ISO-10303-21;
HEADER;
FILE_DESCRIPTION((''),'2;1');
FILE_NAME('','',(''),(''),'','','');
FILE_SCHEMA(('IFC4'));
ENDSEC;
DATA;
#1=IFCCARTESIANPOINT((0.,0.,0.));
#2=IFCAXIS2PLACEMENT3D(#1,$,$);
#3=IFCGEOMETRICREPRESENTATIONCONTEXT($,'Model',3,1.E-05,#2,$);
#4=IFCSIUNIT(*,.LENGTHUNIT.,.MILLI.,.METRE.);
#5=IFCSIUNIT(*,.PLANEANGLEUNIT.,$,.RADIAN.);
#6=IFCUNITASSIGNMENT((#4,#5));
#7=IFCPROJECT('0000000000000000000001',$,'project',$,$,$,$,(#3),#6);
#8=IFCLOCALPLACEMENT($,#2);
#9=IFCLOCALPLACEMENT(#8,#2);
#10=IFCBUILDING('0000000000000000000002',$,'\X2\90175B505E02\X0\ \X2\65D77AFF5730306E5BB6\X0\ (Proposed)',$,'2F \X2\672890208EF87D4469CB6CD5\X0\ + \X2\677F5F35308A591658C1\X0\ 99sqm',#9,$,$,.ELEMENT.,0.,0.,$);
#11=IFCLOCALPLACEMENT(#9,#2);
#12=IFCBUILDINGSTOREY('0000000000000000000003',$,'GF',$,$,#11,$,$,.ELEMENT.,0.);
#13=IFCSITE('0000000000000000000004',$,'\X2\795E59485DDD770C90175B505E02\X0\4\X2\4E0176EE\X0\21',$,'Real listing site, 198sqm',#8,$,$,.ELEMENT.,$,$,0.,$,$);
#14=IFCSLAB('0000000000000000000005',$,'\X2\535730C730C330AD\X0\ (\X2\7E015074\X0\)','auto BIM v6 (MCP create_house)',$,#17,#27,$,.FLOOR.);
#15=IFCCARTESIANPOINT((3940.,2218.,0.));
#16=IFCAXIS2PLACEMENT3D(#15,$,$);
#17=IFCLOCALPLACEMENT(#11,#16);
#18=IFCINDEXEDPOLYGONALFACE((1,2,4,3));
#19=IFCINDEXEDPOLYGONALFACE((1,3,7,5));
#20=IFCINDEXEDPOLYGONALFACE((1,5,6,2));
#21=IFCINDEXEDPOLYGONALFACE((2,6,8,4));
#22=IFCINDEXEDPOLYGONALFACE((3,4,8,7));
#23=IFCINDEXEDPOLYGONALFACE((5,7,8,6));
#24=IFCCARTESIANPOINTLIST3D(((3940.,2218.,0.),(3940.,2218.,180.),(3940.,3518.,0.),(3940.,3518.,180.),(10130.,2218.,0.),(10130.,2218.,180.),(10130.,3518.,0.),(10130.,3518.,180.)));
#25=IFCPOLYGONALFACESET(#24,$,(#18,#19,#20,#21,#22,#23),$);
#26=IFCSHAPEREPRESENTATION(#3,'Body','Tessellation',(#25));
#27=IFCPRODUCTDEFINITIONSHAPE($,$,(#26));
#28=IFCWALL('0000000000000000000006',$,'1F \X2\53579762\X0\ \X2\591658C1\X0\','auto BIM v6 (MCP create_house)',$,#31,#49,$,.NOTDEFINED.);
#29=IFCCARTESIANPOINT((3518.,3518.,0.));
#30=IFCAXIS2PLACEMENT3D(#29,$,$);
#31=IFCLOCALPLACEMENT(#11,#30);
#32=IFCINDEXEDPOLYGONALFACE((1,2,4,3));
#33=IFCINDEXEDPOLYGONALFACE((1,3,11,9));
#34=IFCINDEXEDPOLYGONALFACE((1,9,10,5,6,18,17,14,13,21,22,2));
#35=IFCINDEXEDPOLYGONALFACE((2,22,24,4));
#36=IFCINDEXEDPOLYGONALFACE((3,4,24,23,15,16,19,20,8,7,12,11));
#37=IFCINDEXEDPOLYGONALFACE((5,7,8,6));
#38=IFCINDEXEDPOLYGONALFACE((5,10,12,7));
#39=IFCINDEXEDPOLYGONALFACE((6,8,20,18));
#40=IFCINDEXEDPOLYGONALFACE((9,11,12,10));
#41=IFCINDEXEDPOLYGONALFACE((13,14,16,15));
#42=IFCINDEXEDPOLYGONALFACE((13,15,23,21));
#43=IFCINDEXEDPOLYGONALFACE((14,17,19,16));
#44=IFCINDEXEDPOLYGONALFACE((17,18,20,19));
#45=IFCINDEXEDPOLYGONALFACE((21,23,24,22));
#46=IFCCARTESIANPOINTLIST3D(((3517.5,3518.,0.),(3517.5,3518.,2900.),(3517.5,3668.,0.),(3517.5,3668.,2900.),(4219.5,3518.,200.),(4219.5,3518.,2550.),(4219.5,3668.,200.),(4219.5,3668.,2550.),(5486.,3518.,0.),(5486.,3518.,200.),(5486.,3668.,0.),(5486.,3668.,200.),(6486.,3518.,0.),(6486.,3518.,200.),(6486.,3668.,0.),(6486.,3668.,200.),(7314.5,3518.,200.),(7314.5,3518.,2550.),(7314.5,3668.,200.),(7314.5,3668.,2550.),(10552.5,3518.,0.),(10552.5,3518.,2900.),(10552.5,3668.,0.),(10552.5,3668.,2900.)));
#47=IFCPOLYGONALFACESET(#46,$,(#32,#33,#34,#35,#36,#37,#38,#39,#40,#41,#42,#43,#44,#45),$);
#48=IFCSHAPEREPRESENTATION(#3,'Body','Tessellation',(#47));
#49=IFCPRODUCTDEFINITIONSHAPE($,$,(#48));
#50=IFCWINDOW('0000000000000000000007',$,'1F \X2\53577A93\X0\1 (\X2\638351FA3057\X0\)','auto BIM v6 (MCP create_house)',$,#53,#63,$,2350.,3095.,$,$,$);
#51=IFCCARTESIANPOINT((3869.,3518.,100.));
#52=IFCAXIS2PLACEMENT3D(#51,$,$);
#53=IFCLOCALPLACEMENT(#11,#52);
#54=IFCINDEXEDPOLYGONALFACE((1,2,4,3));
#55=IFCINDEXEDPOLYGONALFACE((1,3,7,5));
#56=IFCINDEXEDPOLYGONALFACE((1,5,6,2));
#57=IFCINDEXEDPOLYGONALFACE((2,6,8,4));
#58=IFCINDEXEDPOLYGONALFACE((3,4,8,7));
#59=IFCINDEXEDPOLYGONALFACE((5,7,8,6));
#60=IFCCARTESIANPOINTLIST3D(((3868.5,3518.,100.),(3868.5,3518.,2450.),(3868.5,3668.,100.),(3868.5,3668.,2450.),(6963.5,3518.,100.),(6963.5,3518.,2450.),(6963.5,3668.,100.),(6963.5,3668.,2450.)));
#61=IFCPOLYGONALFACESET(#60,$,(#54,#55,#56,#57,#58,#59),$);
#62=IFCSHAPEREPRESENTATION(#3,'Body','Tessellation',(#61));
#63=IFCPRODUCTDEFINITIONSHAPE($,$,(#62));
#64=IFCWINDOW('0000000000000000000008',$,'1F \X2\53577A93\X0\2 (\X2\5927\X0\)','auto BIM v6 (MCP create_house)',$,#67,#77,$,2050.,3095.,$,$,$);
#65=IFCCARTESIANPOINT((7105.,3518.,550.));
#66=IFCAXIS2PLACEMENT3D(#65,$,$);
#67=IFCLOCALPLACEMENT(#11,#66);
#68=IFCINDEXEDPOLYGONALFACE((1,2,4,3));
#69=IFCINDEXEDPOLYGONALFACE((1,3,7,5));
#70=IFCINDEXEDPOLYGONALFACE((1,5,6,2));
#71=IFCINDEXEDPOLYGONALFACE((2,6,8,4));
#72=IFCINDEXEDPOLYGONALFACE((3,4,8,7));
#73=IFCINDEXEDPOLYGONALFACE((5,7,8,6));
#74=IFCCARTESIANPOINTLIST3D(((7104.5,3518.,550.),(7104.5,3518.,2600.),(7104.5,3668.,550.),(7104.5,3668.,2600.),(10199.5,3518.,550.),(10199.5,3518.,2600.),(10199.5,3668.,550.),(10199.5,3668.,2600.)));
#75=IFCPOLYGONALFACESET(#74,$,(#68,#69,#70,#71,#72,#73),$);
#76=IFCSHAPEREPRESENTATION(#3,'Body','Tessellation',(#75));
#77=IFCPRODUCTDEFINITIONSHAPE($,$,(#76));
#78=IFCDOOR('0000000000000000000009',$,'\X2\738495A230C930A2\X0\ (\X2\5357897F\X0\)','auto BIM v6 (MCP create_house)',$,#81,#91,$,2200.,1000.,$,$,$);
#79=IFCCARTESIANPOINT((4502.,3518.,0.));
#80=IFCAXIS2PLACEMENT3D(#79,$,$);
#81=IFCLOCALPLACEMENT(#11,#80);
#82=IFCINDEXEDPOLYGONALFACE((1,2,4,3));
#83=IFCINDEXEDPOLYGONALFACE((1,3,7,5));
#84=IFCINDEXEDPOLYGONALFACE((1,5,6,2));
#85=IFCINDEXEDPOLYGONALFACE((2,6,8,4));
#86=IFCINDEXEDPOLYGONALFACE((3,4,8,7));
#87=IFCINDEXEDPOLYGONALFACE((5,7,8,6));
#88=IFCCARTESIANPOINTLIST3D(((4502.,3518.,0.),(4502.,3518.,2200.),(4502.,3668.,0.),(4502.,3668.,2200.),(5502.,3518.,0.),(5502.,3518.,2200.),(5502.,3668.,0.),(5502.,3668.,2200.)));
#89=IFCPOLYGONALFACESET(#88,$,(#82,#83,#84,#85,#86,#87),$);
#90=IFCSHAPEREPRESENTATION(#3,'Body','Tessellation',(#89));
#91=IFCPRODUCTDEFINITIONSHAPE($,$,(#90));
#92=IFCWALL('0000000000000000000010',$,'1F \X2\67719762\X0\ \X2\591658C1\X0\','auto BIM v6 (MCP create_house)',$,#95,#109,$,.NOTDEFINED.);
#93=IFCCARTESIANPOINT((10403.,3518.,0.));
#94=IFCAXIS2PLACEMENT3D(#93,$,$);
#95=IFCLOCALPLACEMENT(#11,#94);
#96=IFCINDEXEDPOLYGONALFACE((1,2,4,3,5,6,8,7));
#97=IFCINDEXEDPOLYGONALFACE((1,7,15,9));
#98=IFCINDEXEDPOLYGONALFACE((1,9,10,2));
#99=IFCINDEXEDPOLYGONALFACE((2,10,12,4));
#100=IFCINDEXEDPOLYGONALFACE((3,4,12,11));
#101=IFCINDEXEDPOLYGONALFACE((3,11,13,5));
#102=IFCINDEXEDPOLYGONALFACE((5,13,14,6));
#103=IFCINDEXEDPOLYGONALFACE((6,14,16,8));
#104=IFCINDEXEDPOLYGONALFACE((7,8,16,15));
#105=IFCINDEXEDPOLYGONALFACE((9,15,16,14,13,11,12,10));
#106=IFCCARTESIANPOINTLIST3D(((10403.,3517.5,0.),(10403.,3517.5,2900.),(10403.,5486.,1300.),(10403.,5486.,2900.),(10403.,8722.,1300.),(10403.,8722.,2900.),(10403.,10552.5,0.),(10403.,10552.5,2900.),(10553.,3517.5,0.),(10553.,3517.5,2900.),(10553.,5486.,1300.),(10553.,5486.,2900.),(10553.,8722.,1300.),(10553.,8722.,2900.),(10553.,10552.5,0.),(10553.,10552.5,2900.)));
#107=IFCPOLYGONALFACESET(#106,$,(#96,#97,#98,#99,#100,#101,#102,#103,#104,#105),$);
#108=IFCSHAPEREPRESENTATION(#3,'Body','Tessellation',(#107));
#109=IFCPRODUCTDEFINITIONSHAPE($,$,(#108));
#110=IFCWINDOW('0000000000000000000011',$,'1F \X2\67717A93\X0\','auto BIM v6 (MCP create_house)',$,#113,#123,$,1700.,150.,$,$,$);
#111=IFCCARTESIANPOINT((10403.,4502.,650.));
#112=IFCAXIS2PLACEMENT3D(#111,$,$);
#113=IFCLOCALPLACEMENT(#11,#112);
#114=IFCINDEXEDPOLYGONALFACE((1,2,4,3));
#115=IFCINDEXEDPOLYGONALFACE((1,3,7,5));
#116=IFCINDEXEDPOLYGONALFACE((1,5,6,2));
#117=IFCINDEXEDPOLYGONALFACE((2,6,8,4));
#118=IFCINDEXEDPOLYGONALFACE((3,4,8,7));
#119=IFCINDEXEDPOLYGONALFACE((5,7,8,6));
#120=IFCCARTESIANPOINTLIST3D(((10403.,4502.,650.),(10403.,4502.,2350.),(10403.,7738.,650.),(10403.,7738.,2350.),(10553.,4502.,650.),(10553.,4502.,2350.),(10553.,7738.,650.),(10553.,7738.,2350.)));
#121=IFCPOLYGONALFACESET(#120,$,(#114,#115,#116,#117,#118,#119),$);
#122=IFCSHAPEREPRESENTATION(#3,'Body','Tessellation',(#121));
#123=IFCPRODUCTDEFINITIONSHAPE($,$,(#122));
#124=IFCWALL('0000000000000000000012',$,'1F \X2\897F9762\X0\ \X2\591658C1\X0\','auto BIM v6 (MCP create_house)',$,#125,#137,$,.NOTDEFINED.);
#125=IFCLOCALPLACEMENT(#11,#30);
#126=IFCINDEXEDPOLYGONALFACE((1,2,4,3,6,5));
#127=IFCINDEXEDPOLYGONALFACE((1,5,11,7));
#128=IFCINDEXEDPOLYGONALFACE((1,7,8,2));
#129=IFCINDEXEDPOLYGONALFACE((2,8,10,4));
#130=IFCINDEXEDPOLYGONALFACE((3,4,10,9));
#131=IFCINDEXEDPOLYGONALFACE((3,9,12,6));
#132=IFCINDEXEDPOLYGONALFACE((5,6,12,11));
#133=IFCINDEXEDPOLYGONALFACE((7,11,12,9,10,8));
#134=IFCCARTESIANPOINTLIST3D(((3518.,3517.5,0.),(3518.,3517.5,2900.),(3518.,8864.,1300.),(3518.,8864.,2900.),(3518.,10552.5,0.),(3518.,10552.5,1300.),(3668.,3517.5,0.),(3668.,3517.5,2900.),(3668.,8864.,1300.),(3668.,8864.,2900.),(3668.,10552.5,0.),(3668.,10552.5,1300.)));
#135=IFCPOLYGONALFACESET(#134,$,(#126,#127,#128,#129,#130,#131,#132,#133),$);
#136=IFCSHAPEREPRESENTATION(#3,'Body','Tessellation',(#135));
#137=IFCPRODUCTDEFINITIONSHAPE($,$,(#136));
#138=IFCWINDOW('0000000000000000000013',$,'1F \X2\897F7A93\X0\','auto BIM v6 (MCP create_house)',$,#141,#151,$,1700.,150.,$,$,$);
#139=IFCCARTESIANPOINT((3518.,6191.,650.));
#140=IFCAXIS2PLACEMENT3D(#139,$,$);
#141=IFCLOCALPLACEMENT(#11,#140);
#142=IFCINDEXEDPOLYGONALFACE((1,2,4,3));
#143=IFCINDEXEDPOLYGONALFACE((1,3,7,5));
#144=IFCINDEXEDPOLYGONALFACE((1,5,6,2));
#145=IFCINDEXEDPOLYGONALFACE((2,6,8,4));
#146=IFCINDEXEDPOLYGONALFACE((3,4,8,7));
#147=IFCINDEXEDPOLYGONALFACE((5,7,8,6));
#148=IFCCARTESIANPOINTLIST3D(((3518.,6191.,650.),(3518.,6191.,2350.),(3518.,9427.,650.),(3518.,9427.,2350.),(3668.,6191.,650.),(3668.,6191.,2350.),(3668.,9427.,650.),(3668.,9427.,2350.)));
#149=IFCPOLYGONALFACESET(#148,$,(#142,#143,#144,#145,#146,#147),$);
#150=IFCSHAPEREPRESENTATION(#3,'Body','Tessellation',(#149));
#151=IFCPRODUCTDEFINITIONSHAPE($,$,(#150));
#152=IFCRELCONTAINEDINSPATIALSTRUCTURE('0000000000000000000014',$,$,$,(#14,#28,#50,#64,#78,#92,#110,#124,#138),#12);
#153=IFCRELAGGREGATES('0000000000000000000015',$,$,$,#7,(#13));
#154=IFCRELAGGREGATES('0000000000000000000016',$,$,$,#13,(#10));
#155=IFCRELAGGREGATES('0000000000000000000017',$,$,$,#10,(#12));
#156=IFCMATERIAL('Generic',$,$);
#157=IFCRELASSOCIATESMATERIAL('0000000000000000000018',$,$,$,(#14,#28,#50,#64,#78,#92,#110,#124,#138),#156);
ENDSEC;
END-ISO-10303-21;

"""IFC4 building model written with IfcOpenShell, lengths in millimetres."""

from ifc_helpers import new_model, si_unit, frame, frame_2d, origin, place, context, project, spatial, rectangle, extrude, material, element, fill, save


model = new_model("IFC4")

# Units and contexts
model_context = context("Model", 3, precision=1e-05, world=origin())
ifc_project = project(units=[si_unit("LENGTHUNIT", "METRE", prefix="MILLI"), si_unit("PLANEANGLEUNIT", "RADIAN")], contexts=[model_context])

# Site, building, storey
site_placement = place(None, origin())
site = spatial("IfcSite", under=ifc_project, at=site_placement, Name="神奈川県逗子市4丁目21", ObjectType="Real listing site, 198sqm", CompositionType="ELEMENT", RefElevation=0.0)
building_placement = place(site_placement, origin())
building = spatial("IfcBuilding", under=site, at=building_placement, Name="逗子市 旗竿地の家 (Proposed)", ObjectType="2F 木造軸組構法 + 板張り外壁 99sqm", CompositionType="ELEMENT", ElevationOfRefHeight=0.0, ElevationOfTerrain=0.0)
storey_placement = place(building_placement, origin())
storey = spatial("IfcBuildingStorey", under=building, at=storey_placement, Name="GF", CompositionType="ELEMENT", Elevation=0.0)

# Slab
ifc_material = material(Name="Generic")
slab_1_placement = place(storey_placement, frame((3940.0, 2218.0, 0.0)))
element("IfcSlab", 1, at=slab_1_placement, inside=storey, material=ifc_material, Name="南デッキ (縁側)", Description="auto BIM v6 (MCP create_house)", PredefinedType="FLOOR", context=model_context, shape_type="SweptSolid", body=[
    extrude(rectangle(XDim=6190.0, YDim=1300.0, at=frame_2d((3095.0, 650.0))), frame((3940.0, 2218.0, 0.0)), (0.0, 0.0, 1.0), 180.0),
])

# Wall, openings, windows, door
wall_1_placement = place(storey_placement, frame((3518.0, 3518.0, 0.0)))
wall_1 = element("IfcWall", 2, at=wall_1_placement, inside=storey, material=ifc_material, Name="1F 南面 外壁", Description="auto BIM v6 (MCP create_house)", PredefinedType="NOTDEFINED", context=model_context, shape_type="SweptSolid", body=[
    extrude(rectangle(XDim=7035.0, YDim=150.0, at=frame_2d((3517.0, 75.0))), frame((3518.0, 3518.0, 0.0)), (0.0, 0.0, 1.0), 2900.0),
])
opening_1_placement = place(storey_placement, frame((3869.0, 3518.0, 100.0)))
opening_1 = element("IfcOpeningElement", 3, at=opening_1_placement, cuts=wall_1, PredefinedType="NOTDEFINED", context=model_context, shape_type="SweptSolid", body=[
    extrude(rectangle(XDim=3095.0, YDim=150.0, at=frame_2d((1547.0, 75.0))), frame((3869.0, 3518.0, 100.0)), (0.0, 0.0, 1.0), 2350.0),
])
opening_2_placement = place(storey_placement, frame((7105.0, 3518.0, 550.0)))
opening_2 = element("IfcOpeningElement", 4, at=opening_2_placement, cuts=wall_1, PredefinedType="NOTDEFINED", context=model_context, shape_type="SweptSolid", body=[
    extrude(rectangle(XDim=3095.0, YDim=150.0, at=frame_2d((1547.0, 75.0))), frame((7105.0, 3518.0, 550.0)), (0.0, 0.0, 1.0), 2050.0),
])
opening_3_placement = place(storey_placement, frame((4502.0, 3518.0, 0.0)))
opening_3 = element("IfcOpeningElement", 5, at=opening_3_placement, cuts=wall_1, PredefinedType="NOTDEFINED", context=model_context, shape_type="SweptSolid", body=[
    extrude(rectangle(XDim=1000.0, YDim=150.0, at=frame_2d((500.0, 75.0))), frame((4502.0, 3518.0, 0.0)), (0.0, 0.0, 1.0), 2200.0),
])
window_1_placement = place(storey_placement, frame((3869.0, 3518.0, 100.0)))
window_1 = element("IfcWindow", 6, at=window_1_placement, inside=storey, material=ifc_material, Name="1F 南窓1 (掃出し)", Description="auto BIM v6 (MCP create_house)", OverallHeight=2350.0, OverallWidth=3095.0, context=model_context, shape_type="SweptSolid", body=[
    extrude(rectangle(XDim=3095.0, YDim=150.0, at=frame_2d((1547.0, 75.0))), frame((3869.0, 3518.0, 100.0)), (0.0, 0.0, 1.0), 2350.0),
])
fill(opening_1, window_1)
window_2_placement = place(storey_placement, frame((7105.0, 3518.0, 550.0)))
window_2 = element("IfcWindow", 7, at=window_2_placement, inside=storey, material=ifc_material, Name="1F 南窓2 (大)", Description="auto BIM v6 (MCP create_house)", OverallHeight=2050.0, OverallWidth=3095.0, context=model_context, shape_type="SweptSolid", body=[
    extrude(rectangle(XDim=3095.0, YDim=150.0, at=frame_2d((1547.0, 75.0))), frame((7105.0, 3518.0, 550.0)), (0.0, 0.0, 1.0), 2050.0),
])
fill(opening_2, window_2)
door_placement = place(storey_placement, frame((4502.0, 3518.0, 0.0)))
door = element("IfcDoor", 8, at=door_placement, inside=storey, material=ifc_material, Name="玄関ドア (南西)", Description="auto BIM v6 (MCP create_house)", OverallHeight=2200.0, OverallWidth=1000.0, context=model_context, shape_type="SweptSolid", body=[
    extrude(rectangle(XDim=1000.0, YDim=150.0, at=frame_2d((500.0, 75.0))), frame((4502.0, 3518.0, 0.0)), (0.0, 0.0, 1.0), 2200.0),
])
fill(opening_3, door)

# Walls, openings, windows
wall_2_placement = place(storey_placement, frame((10403.0, 3518.0, 0.0)))
wall_2 = element("IfcWall", 9, at=wall_2_placement, inside=storey, material=ifc_material, Name="1F 東面 外壁", Description="auto BIM v6 (MCP create_house)", PredefinedType="NOTDEFINED", context=model_context, shape_type="SweptSolid", body=[
    extrude(rectangle(XDim=150.0, YDim=7035.0, at=frame_2d((75.0, 3517.0))), frame((10403.0, 3518.0, 0.0)), (0.0, 0.0, 1.0), 2900.0),
])
opening_4_placement = place(storey_placement, frame((10403.0, 4502.0, 650.0)))
opening_4 = element("IfcOpeningElement", 10, at=opening_4_placement, cuts=wall_2, PredefinedType="NOTDEFINED", context=model_context, shape_type="SweptSolid", body=[
    extrude(rectangle(XDim=150.0, YDim=3236.0, at=frame_2d((75.0, 1618.0))), frame((10403.0, 4502.0, 650.0)), (0.0, 0.0, 1.0), 1700.0),
])
window_3_placement = place(storey_placement, frame((10403.0, 4502.0, 650.0)))
window_3 = element("IfcWindow", 11, at=window_3_placement, inside=storey, material=ifc_material, Name="1F 東窓", Description="auto BIM v6 (MCP create_house)", OverallHeight=1700.0, OverallWidth=150.0, context=model_context, shape_type="SweptSolid", body=[
    extrude(rectangle(XDim=150.0, YDim=3236.0, at=frame_2d((75.0, 1618.0))), frame((10403.0, 4502.0, 650.0)), (0.0, 0.0, 1.0), 1700.0),
])
fill(opening_4, window_3)
wall_3_placement = place(storey_placement, frame((3518.0, 3518.0, 0.0)))
wall_3 = element("IfcWall", 12, at=wall_3_placement, inside=storey, material=ifc_material, Name="1F 西面 外壁", Description="auto BIM v6 (MCP create_house)", PredefinedType="NOTDEFINED", context=model_context, shape_type="SweptSolid", body=[
    extrude(rectangle(XDim=150.0, YDim=7035.0, at=frame_2d((75.0, 3517.0))), frame((3518.0, 3518.0, 0.0)), (0.0, 0.0, 1.0), 2900.0),
])
opening_5_placement = place(storey_placement, frame((3518.0, 6191.0, 650.0)))
opening_5 = element("IfcOpeningElement", 13, at=opening_5_placement, cuts=wall_3, PredefinedType="NOTDEFINED", context=model_context, shape_type="SweptSolid", body=[
    extrude(rectangle(XDim=150.0, YDim=3236.0, at=frame_2d((75.0, 1618.0))), frame((3518.0, 6191.0, 650.0)), (0.0, 0.0, 1.0), 1700.0),
])
window_4_placement = place(storey_placement, frame((3518.0, 6191.0, 650.0)))
window_4 = element("IfcWindow", 14, at=window_4_placement, inside=storey, material=ifc_material, Name="1F 西窓", Description="auto BIM v6 (MCP create_house)", OverallHeight=1700.0, OverallWidth=150.0, context=model_context, shape_type="SweptSolid", body=[
    extrude(rectangle(XDim=150.0, YDim=3236.0, at=frame_2d((75.0, 1618.0))), frame((3518.0, 6191.0, 650.0)), (0.0, 0.0, 1.0), 1700.0),
])
fill(opening_5, window_4)

save(model, "model.ifc")
